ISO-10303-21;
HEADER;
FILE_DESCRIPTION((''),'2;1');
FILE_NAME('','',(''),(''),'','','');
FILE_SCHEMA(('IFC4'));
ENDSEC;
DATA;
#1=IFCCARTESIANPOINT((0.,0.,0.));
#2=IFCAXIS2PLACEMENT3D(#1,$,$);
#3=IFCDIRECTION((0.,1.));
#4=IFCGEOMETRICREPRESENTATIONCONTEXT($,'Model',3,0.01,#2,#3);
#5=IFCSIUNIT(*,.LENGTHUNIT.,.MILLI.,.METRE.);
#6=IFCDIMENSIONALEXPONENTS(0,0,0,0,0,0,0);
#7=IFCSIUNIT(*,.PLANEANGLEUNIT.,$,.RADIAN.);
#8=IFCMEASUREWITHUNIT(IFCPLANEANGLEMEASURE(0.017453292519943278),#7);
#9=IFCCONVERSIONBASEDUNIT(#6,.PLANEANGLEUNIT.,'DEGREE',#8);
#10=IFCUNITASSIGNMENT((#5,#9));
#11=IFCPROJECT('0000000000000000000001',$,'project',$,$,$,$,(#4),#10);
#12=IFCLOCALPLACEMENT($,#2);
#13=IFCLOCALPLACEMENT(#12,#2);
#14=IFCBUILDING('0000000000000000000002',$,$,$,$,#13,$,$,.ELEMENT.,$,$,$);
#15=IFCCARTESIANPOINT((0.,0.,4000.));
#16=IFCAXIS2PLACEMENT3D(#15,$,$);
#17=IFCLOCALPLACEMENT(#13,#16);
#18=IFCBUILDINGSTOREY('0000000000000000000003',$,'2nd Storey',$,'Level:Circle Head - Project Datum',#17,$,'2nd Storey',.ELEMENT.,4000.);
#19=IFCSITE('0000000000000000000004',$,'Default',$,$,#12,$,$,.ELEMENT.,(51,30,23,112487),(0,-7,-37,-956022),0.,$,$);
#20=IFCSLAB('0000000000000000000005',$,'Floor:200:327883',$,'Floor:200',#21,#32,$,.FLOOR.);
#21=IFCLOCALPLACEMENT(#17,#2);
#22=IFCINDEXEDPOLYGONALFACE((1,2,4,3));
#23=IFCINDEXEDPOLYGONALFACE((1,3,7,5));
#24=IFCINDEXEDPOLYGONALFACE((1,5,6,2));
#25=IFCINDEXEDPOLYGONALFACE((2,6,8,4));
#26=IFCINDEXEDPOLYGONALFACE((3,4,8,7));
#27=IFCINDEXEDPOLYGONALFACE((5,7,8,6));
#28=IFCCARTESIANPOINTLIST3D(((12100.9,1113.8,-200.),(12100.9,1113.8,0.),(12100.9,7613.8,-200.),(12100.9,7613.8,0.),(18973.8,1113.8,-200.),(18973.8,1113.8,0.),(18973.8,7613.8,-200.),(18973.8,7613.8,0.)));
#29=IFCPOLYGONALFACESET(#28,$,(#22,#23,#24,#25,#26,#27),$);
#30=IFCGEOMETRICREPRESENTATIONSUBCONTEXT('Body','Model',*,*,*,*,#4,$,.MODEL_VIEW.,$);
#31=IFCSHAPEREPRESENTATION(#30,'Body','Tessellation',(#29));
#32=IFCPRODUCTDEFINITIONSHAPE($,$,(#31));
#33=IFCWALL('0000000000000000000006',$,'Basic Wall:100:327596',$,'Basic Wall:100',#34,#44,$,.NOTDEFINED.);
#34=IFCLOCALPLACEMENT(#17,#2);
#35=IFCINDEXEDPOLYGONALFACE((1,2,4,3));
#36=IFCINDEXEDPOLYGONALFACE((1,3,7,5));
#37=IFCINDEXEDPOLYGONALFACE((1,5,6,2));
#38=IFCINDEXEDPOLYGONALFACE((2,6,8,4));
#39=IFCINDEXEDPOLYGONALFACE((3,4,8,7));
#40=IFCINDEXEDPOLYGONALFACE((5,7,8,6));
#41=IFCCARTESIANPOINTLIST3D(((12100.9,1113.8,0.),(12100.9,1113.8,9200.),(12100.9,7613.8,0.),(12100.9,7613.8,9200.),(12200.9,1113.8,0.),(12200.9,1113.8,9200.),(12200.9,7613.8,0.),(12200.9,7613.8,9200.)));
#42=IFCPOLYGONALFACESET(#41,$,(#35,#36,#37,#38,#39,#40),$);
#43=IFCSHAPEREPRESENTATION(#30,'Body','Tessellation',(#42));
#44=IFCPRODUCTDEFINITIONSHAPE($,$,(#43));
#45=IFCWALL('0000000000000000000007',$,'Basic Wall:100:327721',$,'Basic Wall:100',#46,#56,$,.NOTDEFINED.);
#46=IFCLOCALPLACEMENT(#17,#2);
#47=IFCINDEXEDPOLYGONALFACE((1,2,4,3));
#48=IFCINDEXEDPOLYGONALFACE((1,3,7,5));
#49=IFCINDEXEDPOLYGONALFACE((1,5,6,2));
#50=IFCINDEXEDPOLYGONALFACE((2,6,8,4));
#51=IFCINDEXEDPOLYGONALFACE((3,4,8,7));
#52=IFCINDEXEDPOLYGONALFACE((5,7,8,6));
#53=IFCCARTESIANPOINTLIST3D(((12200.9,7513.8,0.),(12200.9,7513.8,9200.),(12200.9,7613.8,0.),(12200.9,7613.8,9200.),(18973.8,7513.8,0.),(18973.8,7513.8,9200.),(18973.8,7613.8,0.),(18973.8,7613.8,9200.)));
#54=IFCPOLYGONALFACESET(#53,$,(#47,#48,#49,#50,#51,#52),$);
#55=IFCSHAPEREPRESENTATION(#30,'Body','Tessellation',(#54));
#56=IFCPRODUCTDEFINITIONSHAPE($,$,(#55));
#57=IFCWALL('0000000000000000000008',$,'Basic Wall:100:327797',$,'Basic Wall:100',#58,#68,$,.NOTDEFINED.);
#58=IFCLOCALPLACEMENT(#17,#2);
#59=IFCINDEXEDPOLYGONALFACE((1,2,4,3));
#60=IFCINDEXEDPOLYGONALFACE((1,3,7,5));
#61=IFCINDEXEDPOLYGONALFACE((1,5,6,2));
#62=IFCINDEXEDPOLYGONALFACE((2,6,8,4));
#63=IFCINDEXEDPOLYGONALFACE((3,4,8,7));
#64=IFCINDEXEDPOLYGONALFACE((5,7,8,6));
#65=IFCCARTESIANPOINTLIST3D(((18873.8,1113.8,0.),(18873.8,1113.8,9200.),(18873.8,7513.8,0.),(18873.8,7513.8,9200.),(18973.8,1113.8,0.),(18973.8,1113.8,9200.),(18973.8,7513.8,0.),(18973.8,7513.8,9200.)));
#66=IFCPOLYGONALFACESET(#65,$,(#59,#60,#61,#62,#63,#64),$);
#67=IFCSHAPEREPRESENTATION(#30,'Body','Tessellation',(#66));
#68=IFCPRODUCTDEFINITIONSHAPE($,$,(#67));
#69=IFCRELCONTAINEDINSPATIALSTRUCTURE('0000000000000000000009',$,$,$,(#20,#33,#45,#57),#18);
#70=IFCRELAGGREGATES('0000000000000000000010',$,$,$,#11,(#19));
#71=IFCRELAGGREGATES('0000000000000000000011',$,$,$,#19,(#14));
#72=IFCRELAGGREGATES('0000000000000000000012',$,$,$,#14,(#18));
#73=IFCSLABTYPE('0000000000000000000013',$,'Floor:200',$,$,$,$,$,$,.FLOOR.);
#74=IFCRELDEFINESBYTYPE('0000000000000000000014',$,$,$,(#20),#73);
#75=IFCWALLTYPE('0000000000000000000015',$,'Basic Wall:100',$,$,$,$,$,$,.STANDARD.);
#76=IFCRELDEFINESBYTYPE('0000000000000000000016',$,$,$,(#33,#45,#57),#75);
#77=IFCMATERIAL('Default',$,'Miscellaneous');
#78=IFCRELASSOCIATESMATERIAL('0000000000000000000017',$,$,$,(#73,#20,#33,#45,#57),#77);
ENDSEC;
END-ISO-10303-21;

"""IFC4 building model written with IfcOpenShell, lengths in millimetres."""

from ifc_helpers import new_model, entity, si_unit, converted_unit, direction, frame, origin, place, context, subcontext, project, spatial, indexed_curve, outline, extrude, material, type_object, element, save


model = new_model("IFC4")

# Units and contexts
model_context = context("Model", 3, precision=0.01, world=origin(), true_north=direction((0.0, 1.0)))
body_context = subcontext(model_context, "Body", "Model", "MODEL_VIEW")
ifc_project = project(units=[si_unit("LENGTHUNIT", "METRE", prefix="MILLI"), converted_unit("PLANEANGLEUNIT", "DEGREE", entity("IfcPlaneAngleMeasure", 0.017453292519943278), si_unit("PLANEANGLEUNIT", "RADIAN"), dimensions=[0, 0, 0, 0, 0, 0, 0])], contexts=[model_context])

# Site, building, storey
site_placement = place(None, origin())
site = spatial("IfcSite", under=ifc_project, at=site_placement, Name="Default", CompositionType="ELEMENT", RefLatitude=(51, 30, 23, 112487), RefLongitude=(0, -7, -37, -956022), RefElevation=0.0)
building_placement = place(site_placement, origin())
building = spatial("IfcBuilding", under=site, at=building_placement, CompositionType="ELEMENT")
storey_placement = place(building_placement, frame((0.0, 0.0, 4000.0)))
storey = spatial("IfcBuildingStorey", under=building, at=storey_placement, Name="2nd Storey", ObjectType="Level:Circle Head - Project Datum", LongName="2nd Storey", CompositionType="ELEMENT", Elevation=4000.0)

# Slab
ifc_material = material(Name="Default", Category="Miscellaneous")
slab_type = type_object("IfcSlabType", Name="Floor:200", PredefinedType="FLOOR", material=ifc_material)
slab_placement = place(storey_placement, origin())
element("IfcSlab", 1, at=slab_placement, inside=storey, type_object=slab_type, material=ifc_material, Name="Floor:200:327883", ObjectType="Floor:200", PredefinedType="FLOOR", context=body_context, shape_type="SweptSolid", body=[
    extrude(outline(indexed_curve([(-3250.0, -3436.4), (3250.0, -3436.4), (3250.0, 3436.4), (-3250.0, 3436.4), (-3250.0, -3436.4)], self_intersect=False)), frame((15537.4, 4363.8, 0.0), z_axis=(0.0, 0.0, -1.0), x_axis=(0.0, 1.0, 0.0)), (0.0, 0.0, 1.0), 200.0),
])

# Walls
wall_type = type_object("IfcWallType", Name="Basic Wall:100", PredefinedType="STANDARD")
wall_1_placement = place(storey_placement, frame((12150.9, 1113.8, 0.0), z_axis=(0.0, 0.0, 1.0), x_axis=(0.0, 1.0, 0.0)))
element("IfcWall", 2, at=wall_1_placement, inside=storey, type_object=wall_type, material=ifc_material, Name="Basic Wall:100:327596", ObjectType="Basic Wall:100", PredefinedType="NOTDEFINED", context=body_context, shape_type="SweptSolid", body=[
    extrude(outline(indexed_curve([(6500.0, 50.0), (0.0, 50.0), (0.0, -50.0), (6500.0, -50.0), (6500.0, 50.0)], self_intersect=False)), origin(), (0.0, 0.0, 1.0), 9200.0),
])
wall_2_placement = place(storey_placement, frame((12200.9, 7563.8, 0.0)))
element("IfcWall", 3, at=wall_2_placement, inside=storey, type_object=wall_type, material=ifc_material, Name="Basic Wall:100:327721", ObjectType="Basic Wall:100", PredefinedType="NOTDEFINED", context=body_context, shape_type="SweptSolid", body=[
    extrude(outline(indexed_curve([(6772.9, 50.0), (0.0, 50.0), (0.0, -50.0), (6772.9, -50.0), (6772.9, 50.0)], self_intersect=False)), origin(), (0.0, 0.0, 1.0), 9200.0),
])
wall_3_placement = place(storey_placement, frame((18923.8, 7513.8, 0.0), z_axis=(0.0, 0.0, 1.0), x_axis=(0.0, -1.0, 0.0)))
element("IfcWall", 4, at=wall_3_placement, inside=storey, type_object=wall_type, material=ifc_material, Name="Basic Wall:100:327797", ObjectType="Basic Wall:100", PredefinedType="NOTDEFINED", context=body_context, shape_type="SweptSolid", body=[
    extrude(outline(indexed_curve([(6400.0, 50.0), (0.0, 50.0), (0.0, -50.0), (6400.0, -50.0), (6400.0, 50.0)], self_intersect=False)), origin(), (0.0, 0.0, 1.0), 9200.0),
])

save(model, "model.ifc")
